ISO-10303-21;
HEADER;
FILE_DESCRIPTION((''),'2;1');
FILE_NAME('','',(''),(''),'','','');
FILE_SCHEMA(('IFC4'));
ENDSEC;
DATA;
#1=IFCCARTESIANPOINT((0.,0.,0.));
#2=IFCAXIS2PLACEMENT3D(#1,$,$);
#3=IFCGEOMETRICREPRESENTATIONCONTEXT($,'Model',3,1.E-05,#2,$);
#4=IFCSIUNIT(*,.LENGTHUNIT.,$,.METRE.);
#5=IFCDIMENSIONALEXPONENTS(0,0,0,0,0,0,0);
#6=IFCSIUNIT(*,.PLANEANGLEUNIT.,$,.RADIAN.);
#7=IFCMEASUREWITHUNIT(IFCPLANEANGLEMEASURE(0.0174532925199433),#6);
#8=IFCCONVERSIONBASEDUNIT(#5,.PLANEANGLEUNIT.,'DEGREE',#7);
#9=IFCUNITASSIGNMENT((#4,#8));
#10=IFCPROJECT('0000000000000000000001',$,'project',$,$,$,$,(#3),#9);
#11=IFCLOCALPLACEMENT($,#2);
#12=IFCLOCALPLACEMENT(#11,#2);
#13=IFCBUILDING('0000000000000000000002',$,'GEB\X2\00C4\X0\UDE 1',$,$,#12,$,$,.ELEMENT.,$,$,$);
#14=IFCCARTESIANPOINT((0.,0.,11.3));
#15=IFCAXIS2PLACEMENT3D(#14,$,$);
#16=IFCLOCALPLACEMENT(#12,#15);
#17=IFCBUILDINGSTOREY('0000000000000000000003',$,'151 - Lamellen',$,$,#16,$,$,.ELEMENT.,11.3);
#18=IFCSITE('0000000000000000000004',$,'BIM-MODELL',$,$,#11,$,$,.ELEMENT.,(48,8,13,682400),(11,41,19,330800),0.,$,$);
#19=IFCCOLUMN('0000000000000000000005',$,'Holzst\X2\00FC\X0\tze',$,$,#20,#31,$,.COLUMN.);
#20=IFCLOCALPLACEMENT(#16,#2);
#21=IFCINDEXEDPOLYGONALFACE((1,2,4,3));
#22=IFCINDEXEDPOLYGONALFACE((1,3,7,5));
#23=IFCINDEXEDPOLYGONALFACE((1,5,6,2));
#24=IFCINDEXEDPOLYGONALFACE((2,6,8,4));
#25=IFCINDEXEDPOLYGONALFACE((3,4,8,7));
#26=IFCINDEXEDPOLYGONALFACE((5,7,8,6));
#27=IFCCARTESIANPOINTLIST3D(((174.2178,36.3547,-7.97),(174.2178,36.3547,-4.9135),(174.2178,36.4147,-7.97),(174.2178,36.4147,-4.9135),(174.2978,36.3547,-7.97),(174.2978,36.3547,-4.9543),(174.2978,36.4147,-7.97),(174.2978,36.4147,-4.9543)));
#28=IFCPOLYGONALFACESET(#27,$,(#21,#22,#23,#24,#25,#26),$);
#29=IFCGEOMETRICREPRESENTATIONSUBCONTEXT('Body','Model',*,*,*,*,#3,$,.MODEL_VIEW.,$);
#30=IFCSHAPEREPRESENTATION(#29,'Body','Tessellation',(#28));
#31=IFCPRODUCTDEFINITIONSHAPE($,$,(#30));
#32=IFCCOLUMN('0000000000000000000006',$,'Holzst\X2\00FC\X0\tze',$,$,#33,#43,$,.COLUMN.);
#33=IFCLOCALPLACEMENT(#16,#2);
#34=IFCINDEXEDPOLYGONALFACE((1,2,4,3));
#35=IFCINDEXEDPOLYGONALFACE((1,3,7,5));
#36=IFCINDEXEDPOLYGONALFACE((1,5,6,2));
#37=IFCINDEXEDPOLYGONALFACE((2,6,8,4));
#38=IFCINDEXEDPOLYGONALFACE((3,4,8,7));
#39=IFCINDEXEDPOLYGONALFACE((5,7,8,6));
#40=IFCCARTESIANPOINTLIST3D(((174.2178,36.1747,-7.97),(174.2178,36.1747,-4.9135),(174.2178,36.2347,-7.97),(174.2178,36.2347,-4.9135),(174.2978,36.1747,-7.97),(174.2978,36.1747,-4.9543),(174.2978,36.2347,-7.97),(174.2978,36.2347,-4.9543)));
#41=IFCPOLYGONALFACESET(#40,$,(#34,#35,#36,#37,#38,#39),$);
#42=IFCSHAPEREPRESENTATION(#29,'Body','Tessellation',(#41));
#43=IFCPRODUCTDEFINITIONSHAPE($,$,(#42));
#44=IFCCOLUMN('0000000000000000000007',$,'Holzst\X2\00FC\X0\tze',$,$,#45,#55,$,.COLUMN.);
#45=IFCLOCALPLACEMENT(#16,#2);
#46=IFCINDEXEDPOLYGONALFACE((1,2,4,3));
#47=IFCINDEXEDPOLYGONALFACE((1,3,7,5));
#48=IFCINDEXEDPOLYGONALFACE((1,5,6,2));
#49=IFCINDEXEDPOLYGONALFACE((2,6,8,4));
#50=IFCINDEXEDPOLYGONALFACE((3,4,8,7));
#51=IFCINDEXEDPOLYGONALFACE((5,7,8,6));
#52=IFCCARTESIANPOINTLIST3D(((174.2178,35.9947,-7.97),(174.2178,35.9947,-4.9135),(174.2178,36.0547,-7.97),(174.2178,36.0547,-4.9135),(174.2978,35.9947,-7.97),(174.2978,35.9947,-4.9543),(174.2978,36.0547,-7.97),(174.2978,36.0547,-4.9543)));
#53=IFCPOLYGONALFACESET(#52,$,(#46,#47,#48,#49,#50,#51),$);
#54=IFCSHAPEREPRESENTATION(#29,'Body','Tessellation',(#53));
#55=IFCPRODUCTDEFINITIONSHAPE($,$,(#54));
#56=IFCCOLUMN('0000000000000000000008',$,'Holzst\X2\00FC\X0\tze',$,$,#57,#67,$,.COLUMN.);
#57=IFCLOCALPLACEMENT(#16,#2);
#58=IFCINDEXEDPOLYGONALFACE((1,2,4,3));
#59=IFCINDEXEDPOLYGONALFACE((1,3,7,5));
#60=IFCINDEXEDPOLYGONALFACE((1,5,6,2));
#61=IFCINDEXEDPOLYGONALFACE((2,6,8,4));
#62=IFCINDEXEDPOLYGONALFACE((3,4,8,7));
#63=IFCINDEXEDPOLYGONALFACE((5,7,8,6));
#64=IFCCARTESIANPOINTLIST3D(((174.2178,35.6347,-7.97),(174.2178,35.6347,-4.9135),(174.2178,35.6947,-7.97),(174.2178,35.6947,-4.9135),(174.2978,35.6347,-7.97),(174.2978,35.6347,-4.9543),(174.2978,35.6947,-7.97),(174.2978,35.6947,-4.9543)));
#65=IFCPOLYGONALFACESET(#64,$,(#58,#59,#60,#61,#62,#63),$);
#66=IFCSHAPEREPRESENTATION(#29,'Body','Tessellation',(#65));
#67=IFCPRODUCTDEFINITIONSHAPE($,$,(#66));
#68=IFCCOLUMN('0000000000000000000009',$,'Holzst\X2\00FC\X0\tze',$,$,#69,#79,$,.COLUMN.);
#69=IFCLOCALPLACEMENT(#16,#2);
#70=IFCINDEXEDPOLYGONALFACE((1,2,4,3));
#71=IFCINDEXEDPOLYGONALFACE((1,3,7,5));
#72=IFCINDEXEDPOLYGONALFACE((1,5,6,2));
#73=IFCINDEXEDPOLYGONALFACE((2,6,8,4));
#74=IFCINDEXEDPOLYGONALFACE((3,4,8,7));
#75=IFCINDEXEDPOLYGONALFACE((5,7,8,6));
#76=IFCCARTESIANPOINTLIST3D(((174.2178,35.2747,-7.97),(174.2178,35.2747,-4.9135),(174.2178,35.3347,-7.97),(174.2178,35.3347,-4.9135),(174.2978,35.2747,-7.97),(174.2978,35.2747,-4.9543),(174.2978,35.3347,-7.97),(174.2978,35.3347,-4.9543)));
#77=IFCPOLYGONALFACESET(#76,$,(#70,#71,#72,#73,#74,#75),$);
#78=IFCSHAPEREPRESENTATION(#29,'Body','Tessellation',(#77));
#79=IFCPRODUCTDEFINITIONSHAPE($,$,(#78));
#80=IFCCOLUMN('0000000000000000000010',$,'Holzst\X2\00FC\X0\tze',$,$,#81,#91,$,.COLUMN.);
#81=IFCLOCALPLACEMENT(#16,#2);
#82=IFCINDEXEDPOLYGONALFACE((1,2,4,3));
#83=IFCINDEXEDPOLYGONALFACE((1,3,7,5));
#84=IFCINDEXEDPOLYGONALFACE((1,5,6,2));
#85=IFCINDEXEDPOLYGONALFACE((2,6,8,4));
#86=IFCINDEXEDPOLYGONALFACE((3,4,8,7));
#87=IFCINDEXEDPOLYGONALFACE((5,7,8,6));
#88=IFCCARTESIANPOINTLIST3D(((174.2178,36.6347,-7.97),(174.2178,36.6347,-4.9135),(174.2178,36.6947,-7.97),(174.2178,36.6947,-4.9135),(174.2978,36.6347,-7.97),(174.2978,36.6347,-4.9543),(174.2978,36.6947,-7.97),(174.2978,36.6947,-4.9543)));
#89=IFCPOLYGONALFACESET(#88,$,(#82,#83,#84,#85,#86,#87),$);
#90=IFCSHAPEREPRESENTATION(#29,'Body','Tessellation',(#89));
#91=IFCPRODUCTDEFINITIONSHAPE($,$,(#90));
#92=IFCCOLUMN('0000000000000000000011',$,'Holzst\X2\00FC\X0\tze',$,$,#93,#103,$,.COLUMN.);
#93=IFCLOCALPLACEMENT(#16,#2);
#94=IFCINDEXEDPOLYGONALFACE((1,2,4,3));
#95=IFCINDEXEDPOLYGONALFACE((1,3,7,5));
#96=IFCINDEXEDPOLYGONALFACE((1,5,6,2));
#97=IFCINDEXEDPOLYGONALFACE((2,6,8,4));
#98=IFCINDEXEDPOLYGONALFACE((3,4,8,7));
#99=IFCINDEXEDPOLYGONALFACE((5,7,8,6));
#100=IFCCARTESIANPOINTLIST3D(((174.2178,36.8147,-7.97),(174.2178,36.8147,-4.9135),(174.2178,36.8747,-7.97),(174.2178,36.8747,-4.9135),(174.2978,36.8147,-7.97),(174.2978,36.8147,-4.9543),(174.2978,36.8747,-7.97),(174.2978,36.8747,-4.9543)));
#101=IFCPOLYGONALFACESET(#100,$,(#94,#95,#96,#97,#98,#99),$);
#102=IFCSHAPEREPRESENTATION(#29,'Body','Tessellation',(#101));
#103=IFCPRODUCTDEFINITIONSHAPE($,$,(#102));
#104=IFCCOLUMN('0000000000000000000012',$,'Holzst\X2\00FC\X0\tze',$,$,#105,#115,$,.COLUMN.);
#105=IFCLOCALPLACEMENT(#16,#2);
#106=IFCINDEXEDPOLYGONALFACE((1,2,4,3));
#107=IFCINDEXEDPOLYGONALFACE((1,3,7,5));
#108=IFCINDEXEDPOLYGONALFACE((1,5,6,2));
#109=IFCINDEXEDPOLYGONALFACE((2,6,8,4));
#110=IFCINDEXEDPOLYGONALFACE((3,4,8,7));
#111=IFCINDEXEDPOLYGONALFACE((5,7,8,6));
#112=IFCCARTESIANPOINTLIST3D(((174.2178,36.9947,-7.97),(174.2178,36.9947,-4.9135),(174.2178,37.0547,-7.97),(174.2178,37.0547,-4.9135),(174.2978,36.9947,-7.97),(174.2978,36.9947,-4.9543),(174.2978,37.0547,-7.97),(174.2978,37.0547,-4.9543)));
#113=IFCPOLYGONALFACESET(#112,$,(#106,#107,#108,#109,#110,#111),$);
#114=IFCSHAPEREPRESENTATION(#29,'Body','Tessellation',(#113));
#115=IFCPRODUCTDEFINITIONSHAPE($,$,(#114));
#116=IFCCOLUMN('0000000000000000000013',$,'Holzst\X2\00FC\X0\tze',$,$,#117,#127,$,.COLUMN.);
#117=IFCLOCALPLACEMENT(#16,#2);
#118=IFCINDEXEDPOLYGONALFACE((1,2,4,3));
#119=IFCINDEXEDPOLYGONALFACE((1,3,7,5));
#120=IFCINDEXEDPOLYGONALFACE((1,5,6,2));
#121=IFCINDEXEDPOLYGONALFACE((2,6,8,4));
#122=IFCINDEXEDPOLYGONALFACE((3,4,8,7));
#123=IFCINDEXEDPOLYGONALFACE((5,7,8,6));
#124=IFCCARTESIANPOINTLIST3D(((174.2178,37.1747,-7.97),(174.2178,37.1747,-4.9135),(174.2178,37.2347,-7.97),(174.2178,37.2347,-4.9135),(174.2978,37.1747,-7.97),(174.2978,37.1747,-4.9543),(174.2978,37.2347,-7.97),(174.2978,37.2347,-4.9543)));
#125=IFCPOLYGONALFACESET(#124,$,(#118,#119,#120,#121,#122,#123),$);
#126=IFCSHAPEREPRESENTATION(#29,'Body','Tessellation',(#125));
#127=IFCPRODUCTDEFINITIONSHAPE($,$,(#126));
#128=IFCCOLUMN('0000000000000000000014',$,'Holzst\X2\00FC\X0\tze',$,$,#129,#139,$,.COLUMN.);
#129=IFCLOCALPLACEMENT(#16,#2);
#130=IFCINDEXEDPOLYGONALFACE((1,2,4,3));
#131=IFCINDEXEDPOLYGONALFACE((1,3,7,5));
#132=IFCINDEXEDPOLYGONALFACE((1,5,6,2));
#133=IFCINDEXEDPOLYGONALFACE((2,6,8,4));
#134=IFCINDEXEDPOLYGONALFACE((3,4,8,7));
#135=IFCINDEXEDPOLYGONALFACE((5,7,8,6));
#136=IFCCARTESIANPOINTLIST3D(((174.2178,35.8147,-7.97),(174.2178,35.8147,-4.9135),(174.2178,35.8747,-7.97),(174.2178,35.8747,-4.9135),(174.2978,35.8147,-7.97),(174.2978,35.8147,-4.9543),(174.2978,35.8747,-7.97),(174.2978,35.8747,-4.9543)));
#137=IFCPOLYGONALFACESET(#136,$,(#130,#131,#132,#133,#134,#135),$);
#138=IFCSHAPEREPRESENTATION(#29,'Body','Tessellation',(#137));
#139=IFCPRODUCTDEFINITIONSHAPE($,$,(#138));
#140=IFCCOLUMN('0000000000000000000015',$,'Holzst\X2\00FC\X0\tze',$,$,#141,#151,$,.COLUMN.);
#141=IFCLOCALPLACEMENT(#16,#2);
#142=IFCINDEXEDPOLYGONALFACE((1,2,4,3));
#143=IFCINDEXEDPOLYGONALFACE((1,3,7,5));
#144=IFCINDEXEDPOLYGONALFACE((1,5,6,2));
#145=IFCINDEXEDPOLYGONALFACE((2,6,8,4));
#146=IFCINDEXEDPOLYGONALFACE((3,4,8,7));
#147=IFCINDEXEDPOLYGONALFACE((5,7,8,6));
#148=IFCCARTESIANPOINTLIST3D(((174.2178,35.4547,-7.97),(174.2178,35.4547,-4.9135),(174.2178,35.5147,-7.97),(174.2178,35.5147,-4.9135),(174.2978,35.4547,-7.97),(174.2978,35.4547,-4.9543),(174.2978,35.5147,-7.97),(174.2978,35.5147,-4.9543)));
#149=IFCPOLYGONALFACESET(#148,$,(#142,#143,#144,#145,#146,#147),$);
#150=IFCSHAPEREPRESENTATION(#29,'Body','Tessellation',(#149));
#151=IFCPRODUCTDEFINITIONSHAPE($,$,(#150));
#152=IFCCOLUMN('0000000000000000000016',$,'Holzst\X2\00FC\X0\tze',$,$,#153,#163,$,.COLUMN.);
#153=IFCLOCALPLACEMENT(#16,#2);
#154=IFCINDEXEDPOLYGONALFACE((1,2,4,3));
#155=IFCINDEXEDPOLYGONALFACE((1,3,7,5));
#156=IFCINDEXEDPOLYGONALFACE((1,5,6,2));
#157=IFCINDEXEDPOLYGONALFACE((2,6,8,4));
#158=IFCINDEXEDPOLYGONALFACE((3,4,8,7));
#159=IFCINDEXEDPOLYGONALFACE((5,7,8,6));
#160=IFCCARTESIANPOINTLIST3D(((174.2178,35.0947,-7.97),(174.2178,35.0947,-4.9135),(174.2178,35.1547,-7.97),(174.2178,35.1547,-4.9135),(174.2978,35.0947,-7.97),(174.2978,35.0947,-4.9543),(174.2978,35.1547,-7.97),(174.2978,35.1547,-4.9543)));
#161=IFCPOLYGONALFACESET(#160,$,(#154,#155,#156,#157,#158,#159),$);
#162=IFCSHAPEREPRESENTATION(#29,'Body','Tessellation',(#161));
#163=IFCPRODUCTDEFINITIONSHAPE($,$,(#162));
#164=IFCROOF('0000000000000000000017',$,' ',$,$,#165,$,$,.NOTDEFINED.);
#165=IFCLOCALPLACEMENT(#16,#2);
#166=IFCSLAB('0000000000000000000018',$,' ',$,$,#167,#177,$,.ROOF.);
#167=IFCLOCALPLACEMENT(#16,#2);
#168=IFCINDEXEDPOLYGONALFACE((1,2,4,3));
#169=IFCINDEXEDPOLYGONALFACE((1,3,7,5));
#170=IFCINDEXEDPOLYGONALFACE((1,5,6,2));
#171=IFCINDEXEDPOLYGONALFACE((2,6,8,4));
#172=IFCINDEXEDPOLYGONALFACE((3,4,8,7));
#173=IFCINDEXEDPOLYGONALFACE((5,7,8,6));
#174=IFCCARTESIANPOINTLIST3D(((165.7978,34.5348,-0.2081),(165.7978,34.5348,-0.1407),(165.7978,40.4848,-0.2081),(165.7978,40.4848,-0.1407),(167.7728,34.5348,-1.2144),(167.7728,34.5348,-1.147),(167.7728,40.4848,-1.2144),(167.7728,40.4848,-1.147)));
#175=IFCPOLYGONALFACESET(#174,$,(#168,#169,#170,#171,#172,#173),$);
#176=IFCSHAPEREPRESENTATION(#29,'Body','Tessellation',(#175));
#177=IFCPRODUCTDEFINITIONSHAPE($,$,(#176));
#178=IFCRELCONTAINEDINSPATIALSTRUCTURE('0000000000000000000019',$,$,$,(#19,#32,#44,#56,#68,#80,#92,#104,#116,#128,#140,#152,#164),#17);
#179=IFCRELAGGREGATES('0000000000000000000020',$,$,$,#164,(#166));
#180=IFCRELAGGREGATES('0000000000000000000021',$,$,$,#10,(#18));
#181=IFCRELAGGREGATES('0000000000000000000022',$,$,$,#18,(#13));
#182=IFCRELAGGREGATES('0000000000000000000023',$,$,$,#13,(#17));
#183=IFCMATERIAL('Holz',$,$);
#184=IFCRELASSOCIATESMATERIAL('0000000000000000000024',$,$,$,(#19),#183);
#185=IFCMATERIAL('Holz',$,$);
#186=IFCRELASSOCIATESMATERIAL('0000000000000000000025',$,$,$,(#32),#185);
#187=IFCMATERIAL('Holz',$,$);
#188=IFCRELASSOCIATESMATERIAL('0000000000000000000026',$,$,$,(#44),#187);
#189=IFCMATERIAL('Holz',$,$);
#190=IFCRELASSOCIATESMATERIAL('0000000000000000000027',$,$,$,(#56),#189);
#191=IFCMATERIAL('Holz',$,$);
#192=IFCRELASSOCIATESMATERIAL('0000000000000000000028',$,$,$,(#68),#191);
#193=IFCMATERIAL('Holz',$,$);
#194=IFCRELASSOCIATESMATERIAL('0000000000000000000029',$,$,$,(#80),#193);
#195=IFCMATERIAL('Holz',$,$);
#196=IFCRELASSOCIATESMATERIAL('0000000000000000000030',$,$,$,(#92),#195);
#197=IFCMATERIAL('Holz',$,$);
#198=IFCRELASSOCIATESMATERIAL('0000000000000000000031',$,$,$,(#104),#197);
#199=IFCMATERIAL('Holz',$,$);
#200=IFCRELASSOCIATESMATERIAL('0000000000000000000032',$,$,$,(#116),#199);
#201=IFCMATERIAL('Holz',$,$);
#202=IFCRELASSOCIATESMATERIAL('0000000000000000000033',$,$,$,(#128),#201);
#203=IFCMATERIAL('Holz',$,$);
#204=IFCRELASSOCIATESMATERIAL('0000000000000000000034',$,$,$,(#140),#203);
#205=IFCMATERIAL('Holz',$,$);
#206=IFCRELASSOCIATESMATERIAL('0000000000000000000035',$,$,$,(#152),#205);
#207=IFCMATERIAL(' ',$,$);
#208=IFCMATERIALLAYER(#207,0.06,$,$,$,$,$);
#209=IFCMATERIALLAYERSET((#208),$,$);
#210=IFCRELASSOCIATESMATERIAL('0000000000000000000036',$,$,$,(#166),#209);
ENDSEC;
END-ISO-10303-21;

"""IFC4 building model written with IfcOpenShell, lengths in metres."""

from ifc_helpers import new_model, entity, si_unit, converted_unit, frame, frame_2d, origin, origin_with_axes, origin_2d_with_axis, place, context, subcontext, project, spatial, rectangle, extrude, clip, halfspace, material, layer, layer_set, layer_usage, element, aggregate, save


model = new_model("IFC4")

# Units and contexts
model_context = context("Model", 3, precision=1e-05, world=origin())
body_context = subcontext(model_context, "Body", "Model", "MODEL_VIEW")
ifc_project = project(units=[si_unit("LENGTHUNIT", "METRE"), converted_unit("PLANEANGLEUNIT", "DEGREE", entity("IfcPlaneAngleMeasure", 0.0174532925199433), si_unit("PLANEANGLEUNIT", "RADIAN"), dimensions=[0, 0, 0, 0, 0, 0, 0])], contexts=[model_context])

# Site, building, storey
site_placement = place(None, origin())
site = spatial("IfcSite", under=ifc_project, at=site_placement, Name="BIM-MODELL", CompositionType="ELEMENT", RefLatitude=(48, 8, 13, 682400), RefLongitude=(11, 41, 19, 330800), RefElevation=0.0)
building_placement = place(site_placement, origin())
building = spatial("IfcBuilding", under=site, at=building_placement, Name="GEBÄUDE 1", CompositionType="ELEMENT")
storey_placement = place(building_placement, frame((0.0, 0.0, 11.3)))
storey = spatial("IfcBuildingStorey", under=building, at=storey_placement, Name="151 - Lamellen", CompositionType="ELEMENT", Elevation=11.3)

# Columns
ifc_material_1 = material(Name="Holz")
column_1_placement = place(storey_placement, frame((174.2978, 36.3547, -7.97)))
element("IfcColumn", 1, at=column_1_placement, inside=storey, material=ifc_material_1, Name="Holzstütze", PredefinedType="COLUMN", context=body_context, shape_type="Clipping", body=[
    clip(extrude(rectangle(XDim=0.06, YDim=0.08, at=frame_2d((-0.04, 0.03), x_axis=(0.0, 1.0))), origin_with_axes(), (0.0, 0.0, 1.0), 3.0565), halfspace(frame((-0.04, 0.03, 3.0361), z_axis=(-0.45399, 0.0, -0.891007), x_axis=(0.891007, 0.0, -0.45399)), True)),
])
ifc_material_2 = material(Name="Holz")
column_2_placement = place(storey_placement, frame((174.2978, 36.1747, -7.97)))
element("IfcColumn", 2, at=column_2_placement, inside=storey, material=ifc_material_2, Name="Holzstütze", PredefinedType="COLUMN", context=body_context, shape_type="Clipping", body=[
    clip(extrude(rectangle(XDim=0.06, YDim=0.08, at=frame_2d((-0.04, 0.03), x_axis=(0.0, 1.0))), origin_with_axes(), (0.0, 0.0, 1.0), 3.0565), halfspace(frame((-0.04, 0.03, 3.0361), z_axis=(-0.45399, 0.0, -0.891007), x_axis=(0.891007, 0.0, -0.45399)), True)),
])
ifc_material_3 = material(Name="Holz")
column_3_placement = place(storey_placement, frame((174.2978, 35.9947, -7.97)))
element("IfcColumn", 3, at=column_3_placement, inside=storey, material=ifc_material_3, Name="Holzstütze", PredefinedType="COLUMN", context=body_context, shape_type="Clipping", body=[
    clip(extrude(rectangle(XDim=0.06, YDim=0.08, at=frame_2d((-0.04, 0.03), x_axis=(0.0, 1.0))), origin_with_axes(), (0.0, 0.0, 1.0), 3.0565), halfspace(frame((-0.04, 0.03, 3.0361), z_axis=(-0.45399, 0.0, -0.891007), x_axis=(0.891007, 0.0, -0.45399)), True)),
])
ifc_material_4 = material(Name="Holz")
column_4_placement = place(storey_placement, frame((174.2978, 35.6347, -7.97)))
element("IfcColumn", 4, at=column_4_placement, inside=storey, material=ifc_material_4, Name="Holzstütze", PredefinedType="COLUMN", context=body_context, shape_type="Clipping", body=[
    clip(extrude(rectangle(XDim=0.06, YDim=0.08, at=frame_2d((-0.04, 0.03), x_axis=(0.0, 1.0))), origin_with_axes(), (0.0, 0.0, 1.0), 3.0565), halfspace(frame((-0.04, 0.03, 3.0361), z_axis=(-0.45399, 0.0, -0.891007), x_axis=(0.891007, 0.0, -0.45399)), True)),
])
ifc_material_5 = material(Name="Holz")
column_5_placement = place(storey_placement, frame((174.2978, 35.2747, -7.97)))
element("IfcColumn", 5, at=column_5_placement, inside=storey, material=ifc_material_5, Name="Holzstütze", PredefinedType="COLUMN", context=body_context, shape_type="Clipping", body=[
    clip(extrude(rectangle(XDim=0.06, YDim=0.08, at=frame_2d((-0.04, 0.03), x_axis=(0.0, 1.0))), origin_with_axes(), (0.0, 0.0, 1.0), 3.0565), halfspace(frame((-0.04, 0.03, 3.0361), z_axis=(-0.45399, 0.0, -0.891007), x_axis=(0.891007, 0.0, -0.45399)), True)),
])
ifc_material_6 = material(Name="Holz")
column_6_placement = place(storey_placement, frame((174.2978, 36.6347, -7.97)))
element("IfcColumn", 6, at=column_6_placement, inside=storey, material=ifc_material_6, Name="Holzstütze", PredefinedType="COLUMN", context=body_context, shape_type="Clipping", body=[
    clip(extrude(rectangle(XDim=0.06, YDim=0.08, at=frame_2d((-0.04, 0.03), x_axis=(0.0, 1.0))), origin_with_axes(), (0.0, 0.0, 1.0), 3.0565), halfspace(frame((-0.04, 0.03, 3.0361), z_axis=(-0.45399, 0.0, -0.891007), x_axis=(0.891007, 0.0, -0.45399)), True)),
])
ifc_material_7 = material(Name="Holz")
column_7_placement = place(storey_placement, frame((174.2978, 36.8147, -7.97)))
element("IfcColumn", 7, at=column_7_placement, inside=storey, material=ifc_material_7, Name="Holzstütze", PredefinedType="COLUMN", context=body_context, shape_type="Clipping", body=[
    clip(extrude(rectangle(XDim=0.06, YDim=0.08, at=frame_2d((-0.04, 0.03), x_axis=(0.0, 1.0))), origin_with_axes(), (0.0, 0.0, 1.0), 3.0565), halfspace(frame((-0.04, 0.03, 3.0361), z_axis=(-0.45399, 0.0, -0.891007), x_axis=(0.891007, 0.0, -0.45399)), True)),
])
ifc_material_8 = material(Name="Holz")
column_8_placement = place(storey_placement, frame((174.2978, 36.9947, -7.97)))
element("IfcColumn", 8, at=column_8_placement, inside=storey, material=ifc_material_8, Name="Holzstütze", PredefinedType="COLUMN", context=body_context, shape_type="Clipping", body=[
    clip(extrude(rectangle(XDim=0.06, YDim=0.08, at=frame_2d((-0.04, 0.03), x_axis=(0.0, 1.0))), origin_with_axes(), (0.0, 0.0, 1.0), 3.0565), halfspace(frame((-0.04, 0.03, 3.0361), z_axis=(-0.45399, 0.0, -0.891007), x_axis=(0.891007, 0.0, -0.45399)), True)),
])
ifc_material_9 = material(Name="Holz")
column_9_placement = place(storey_placement, frame((174.2978, 37.1747, -7.97)))
element("IfcColumn", 9, at=column_9_placement, inside=storey, material=ifc_material_9, Name="Holzstütze", PredefinedType="COLUMN", context=body_context, shape_type="Clipping", body=[
    clip(extrude(rectangle(XDim=0.06, YDim=0.08, at=frame_2d((-0.04, 0.03), x_axis=(0.0, 1.0))), origin_with_axes(), (0.0, 0.0, 1.0), 3.0565), halfspace(frame((-0.04, 0.03, 3.0361), z_axis=(-0.45399, 0.0, -0.891007), x_axis=(0.891007, 0.0, -0.45399)), True)),
])
ifc_material_10 = material(Name="Holz")
column_10_placement = place(storey_placement, frame((174.2978, 35.8147, -7.97)))
element("IfcColumn", 10, at=column_10_placement, inside=storey, material=ifc_material_10, Name="Holzstütze", PredefinedType="COLUMN", context=body_context, shape_type="Clipping", body=[
    clip(extrude(rectangle(XDim=0.06, YDim=0.08, at=frame_2d((-0.04, 0.03), x_axis=(0.0, 1.0))), origin_with_axes(), (0.0, 0.0, 1.0), 3.0565), halfspace(frame((-0.04, 0.03, 3.0361), z_axis=(-0.45399, 0.0, -0.891007), x_axis=(0.891007, 0.0, -0.45399)), True)),
])
ifc_material_11 = material(Name="Holz")
column_11_placement = place(storey_placement, frame((174.2978, 35.4547, -7.97)))
element("IfcColumn", 11, at=column_11_placement, inside=storey, material=ifc_material_11, Name="Holzstütze", PredefinedType="COLUMN", context=body_context, shape_type="Clipping", body=[
    clip(extrude(rectangle(XDim=0.06, YDim=0.08, at=frame_2d((-0.04, 0.03), x_axis=(0.0, 1.0))), origin_with_axes(), (0.0, 0.0, 1.0), 3.0565), halfspace(frame((-0.04, 0.03, 3.0361), z_axis=(-0.45399, 0.0, -0.891007), x_axis=(0.891007, 0.0, -0.45399)), True)),
])
ifc_material_12 = material(Name="Holz")
column_12_placement = place(storey_placement, frame((174.2978, 35.0947, -7.97)))
element("IfcColumn", 12, at=column_12_placement, inside=storey, material=ifc_material_12, Name="Holzstütze", PredefinedType="COLUMN", context=body_context, shape_type="Clipping", body=[
    clip(extrude(rectangle(XDim=0.06, YDim=0.08, at=frame_2d((-0.04, 0.03), x_axis=(0.0, 1.0))), origin_with_axes(), (0.0, 0.0, 1.0), 3.0565), halfspace(frame((-0.04, 0.03, 3.0361), z_axis=(-0.45399, 0.0, -0.891007), x_axis=(0.891007, 0.0, -0.45399)), True)),
])

# Roof, slab
roof_placement = place(storey_placement, frame((0.0, 0.0, -11.3)))
roof = element("IfcRoof", 13, at=roof_placement, inside=storey, Name=" ", PredefinedType="NOTDEFINED")
ifc_material_13 = material(Name=" ")
ifc_layer = layer(ifc_material_13, 0.06)
ifc_layer_set = layer_set([ifc_layer])
ifc_layer_usage = layer_usage(ifc_layer_set, "AXIS3", "POSITIVE", 0.0)
slab_placement = place(roof_placement, frame((165.7978, 34.5348, 10.0856)))
slab = element("IfcSlab", 14, at=slab_placement, material=ifc_layer_usage, Name=" ", PredefinedType="ROOF", context=body_context, shape_type="SweptSolid", body=[
    extrude(rectangle(XDim=5.95, YDim=2.2166, at=origin_2d_with_axis()), frame((0.9875, 2.975, 0.5032), z_axis=(0.45399, 0.0, 0.891007), x_axis=(0.0, -1.0, 0.0)), (0.0, -0.45399, 0.891007), 0.0673),
])
aggregate(roof, [slab])

save(model, "model.ifc")
